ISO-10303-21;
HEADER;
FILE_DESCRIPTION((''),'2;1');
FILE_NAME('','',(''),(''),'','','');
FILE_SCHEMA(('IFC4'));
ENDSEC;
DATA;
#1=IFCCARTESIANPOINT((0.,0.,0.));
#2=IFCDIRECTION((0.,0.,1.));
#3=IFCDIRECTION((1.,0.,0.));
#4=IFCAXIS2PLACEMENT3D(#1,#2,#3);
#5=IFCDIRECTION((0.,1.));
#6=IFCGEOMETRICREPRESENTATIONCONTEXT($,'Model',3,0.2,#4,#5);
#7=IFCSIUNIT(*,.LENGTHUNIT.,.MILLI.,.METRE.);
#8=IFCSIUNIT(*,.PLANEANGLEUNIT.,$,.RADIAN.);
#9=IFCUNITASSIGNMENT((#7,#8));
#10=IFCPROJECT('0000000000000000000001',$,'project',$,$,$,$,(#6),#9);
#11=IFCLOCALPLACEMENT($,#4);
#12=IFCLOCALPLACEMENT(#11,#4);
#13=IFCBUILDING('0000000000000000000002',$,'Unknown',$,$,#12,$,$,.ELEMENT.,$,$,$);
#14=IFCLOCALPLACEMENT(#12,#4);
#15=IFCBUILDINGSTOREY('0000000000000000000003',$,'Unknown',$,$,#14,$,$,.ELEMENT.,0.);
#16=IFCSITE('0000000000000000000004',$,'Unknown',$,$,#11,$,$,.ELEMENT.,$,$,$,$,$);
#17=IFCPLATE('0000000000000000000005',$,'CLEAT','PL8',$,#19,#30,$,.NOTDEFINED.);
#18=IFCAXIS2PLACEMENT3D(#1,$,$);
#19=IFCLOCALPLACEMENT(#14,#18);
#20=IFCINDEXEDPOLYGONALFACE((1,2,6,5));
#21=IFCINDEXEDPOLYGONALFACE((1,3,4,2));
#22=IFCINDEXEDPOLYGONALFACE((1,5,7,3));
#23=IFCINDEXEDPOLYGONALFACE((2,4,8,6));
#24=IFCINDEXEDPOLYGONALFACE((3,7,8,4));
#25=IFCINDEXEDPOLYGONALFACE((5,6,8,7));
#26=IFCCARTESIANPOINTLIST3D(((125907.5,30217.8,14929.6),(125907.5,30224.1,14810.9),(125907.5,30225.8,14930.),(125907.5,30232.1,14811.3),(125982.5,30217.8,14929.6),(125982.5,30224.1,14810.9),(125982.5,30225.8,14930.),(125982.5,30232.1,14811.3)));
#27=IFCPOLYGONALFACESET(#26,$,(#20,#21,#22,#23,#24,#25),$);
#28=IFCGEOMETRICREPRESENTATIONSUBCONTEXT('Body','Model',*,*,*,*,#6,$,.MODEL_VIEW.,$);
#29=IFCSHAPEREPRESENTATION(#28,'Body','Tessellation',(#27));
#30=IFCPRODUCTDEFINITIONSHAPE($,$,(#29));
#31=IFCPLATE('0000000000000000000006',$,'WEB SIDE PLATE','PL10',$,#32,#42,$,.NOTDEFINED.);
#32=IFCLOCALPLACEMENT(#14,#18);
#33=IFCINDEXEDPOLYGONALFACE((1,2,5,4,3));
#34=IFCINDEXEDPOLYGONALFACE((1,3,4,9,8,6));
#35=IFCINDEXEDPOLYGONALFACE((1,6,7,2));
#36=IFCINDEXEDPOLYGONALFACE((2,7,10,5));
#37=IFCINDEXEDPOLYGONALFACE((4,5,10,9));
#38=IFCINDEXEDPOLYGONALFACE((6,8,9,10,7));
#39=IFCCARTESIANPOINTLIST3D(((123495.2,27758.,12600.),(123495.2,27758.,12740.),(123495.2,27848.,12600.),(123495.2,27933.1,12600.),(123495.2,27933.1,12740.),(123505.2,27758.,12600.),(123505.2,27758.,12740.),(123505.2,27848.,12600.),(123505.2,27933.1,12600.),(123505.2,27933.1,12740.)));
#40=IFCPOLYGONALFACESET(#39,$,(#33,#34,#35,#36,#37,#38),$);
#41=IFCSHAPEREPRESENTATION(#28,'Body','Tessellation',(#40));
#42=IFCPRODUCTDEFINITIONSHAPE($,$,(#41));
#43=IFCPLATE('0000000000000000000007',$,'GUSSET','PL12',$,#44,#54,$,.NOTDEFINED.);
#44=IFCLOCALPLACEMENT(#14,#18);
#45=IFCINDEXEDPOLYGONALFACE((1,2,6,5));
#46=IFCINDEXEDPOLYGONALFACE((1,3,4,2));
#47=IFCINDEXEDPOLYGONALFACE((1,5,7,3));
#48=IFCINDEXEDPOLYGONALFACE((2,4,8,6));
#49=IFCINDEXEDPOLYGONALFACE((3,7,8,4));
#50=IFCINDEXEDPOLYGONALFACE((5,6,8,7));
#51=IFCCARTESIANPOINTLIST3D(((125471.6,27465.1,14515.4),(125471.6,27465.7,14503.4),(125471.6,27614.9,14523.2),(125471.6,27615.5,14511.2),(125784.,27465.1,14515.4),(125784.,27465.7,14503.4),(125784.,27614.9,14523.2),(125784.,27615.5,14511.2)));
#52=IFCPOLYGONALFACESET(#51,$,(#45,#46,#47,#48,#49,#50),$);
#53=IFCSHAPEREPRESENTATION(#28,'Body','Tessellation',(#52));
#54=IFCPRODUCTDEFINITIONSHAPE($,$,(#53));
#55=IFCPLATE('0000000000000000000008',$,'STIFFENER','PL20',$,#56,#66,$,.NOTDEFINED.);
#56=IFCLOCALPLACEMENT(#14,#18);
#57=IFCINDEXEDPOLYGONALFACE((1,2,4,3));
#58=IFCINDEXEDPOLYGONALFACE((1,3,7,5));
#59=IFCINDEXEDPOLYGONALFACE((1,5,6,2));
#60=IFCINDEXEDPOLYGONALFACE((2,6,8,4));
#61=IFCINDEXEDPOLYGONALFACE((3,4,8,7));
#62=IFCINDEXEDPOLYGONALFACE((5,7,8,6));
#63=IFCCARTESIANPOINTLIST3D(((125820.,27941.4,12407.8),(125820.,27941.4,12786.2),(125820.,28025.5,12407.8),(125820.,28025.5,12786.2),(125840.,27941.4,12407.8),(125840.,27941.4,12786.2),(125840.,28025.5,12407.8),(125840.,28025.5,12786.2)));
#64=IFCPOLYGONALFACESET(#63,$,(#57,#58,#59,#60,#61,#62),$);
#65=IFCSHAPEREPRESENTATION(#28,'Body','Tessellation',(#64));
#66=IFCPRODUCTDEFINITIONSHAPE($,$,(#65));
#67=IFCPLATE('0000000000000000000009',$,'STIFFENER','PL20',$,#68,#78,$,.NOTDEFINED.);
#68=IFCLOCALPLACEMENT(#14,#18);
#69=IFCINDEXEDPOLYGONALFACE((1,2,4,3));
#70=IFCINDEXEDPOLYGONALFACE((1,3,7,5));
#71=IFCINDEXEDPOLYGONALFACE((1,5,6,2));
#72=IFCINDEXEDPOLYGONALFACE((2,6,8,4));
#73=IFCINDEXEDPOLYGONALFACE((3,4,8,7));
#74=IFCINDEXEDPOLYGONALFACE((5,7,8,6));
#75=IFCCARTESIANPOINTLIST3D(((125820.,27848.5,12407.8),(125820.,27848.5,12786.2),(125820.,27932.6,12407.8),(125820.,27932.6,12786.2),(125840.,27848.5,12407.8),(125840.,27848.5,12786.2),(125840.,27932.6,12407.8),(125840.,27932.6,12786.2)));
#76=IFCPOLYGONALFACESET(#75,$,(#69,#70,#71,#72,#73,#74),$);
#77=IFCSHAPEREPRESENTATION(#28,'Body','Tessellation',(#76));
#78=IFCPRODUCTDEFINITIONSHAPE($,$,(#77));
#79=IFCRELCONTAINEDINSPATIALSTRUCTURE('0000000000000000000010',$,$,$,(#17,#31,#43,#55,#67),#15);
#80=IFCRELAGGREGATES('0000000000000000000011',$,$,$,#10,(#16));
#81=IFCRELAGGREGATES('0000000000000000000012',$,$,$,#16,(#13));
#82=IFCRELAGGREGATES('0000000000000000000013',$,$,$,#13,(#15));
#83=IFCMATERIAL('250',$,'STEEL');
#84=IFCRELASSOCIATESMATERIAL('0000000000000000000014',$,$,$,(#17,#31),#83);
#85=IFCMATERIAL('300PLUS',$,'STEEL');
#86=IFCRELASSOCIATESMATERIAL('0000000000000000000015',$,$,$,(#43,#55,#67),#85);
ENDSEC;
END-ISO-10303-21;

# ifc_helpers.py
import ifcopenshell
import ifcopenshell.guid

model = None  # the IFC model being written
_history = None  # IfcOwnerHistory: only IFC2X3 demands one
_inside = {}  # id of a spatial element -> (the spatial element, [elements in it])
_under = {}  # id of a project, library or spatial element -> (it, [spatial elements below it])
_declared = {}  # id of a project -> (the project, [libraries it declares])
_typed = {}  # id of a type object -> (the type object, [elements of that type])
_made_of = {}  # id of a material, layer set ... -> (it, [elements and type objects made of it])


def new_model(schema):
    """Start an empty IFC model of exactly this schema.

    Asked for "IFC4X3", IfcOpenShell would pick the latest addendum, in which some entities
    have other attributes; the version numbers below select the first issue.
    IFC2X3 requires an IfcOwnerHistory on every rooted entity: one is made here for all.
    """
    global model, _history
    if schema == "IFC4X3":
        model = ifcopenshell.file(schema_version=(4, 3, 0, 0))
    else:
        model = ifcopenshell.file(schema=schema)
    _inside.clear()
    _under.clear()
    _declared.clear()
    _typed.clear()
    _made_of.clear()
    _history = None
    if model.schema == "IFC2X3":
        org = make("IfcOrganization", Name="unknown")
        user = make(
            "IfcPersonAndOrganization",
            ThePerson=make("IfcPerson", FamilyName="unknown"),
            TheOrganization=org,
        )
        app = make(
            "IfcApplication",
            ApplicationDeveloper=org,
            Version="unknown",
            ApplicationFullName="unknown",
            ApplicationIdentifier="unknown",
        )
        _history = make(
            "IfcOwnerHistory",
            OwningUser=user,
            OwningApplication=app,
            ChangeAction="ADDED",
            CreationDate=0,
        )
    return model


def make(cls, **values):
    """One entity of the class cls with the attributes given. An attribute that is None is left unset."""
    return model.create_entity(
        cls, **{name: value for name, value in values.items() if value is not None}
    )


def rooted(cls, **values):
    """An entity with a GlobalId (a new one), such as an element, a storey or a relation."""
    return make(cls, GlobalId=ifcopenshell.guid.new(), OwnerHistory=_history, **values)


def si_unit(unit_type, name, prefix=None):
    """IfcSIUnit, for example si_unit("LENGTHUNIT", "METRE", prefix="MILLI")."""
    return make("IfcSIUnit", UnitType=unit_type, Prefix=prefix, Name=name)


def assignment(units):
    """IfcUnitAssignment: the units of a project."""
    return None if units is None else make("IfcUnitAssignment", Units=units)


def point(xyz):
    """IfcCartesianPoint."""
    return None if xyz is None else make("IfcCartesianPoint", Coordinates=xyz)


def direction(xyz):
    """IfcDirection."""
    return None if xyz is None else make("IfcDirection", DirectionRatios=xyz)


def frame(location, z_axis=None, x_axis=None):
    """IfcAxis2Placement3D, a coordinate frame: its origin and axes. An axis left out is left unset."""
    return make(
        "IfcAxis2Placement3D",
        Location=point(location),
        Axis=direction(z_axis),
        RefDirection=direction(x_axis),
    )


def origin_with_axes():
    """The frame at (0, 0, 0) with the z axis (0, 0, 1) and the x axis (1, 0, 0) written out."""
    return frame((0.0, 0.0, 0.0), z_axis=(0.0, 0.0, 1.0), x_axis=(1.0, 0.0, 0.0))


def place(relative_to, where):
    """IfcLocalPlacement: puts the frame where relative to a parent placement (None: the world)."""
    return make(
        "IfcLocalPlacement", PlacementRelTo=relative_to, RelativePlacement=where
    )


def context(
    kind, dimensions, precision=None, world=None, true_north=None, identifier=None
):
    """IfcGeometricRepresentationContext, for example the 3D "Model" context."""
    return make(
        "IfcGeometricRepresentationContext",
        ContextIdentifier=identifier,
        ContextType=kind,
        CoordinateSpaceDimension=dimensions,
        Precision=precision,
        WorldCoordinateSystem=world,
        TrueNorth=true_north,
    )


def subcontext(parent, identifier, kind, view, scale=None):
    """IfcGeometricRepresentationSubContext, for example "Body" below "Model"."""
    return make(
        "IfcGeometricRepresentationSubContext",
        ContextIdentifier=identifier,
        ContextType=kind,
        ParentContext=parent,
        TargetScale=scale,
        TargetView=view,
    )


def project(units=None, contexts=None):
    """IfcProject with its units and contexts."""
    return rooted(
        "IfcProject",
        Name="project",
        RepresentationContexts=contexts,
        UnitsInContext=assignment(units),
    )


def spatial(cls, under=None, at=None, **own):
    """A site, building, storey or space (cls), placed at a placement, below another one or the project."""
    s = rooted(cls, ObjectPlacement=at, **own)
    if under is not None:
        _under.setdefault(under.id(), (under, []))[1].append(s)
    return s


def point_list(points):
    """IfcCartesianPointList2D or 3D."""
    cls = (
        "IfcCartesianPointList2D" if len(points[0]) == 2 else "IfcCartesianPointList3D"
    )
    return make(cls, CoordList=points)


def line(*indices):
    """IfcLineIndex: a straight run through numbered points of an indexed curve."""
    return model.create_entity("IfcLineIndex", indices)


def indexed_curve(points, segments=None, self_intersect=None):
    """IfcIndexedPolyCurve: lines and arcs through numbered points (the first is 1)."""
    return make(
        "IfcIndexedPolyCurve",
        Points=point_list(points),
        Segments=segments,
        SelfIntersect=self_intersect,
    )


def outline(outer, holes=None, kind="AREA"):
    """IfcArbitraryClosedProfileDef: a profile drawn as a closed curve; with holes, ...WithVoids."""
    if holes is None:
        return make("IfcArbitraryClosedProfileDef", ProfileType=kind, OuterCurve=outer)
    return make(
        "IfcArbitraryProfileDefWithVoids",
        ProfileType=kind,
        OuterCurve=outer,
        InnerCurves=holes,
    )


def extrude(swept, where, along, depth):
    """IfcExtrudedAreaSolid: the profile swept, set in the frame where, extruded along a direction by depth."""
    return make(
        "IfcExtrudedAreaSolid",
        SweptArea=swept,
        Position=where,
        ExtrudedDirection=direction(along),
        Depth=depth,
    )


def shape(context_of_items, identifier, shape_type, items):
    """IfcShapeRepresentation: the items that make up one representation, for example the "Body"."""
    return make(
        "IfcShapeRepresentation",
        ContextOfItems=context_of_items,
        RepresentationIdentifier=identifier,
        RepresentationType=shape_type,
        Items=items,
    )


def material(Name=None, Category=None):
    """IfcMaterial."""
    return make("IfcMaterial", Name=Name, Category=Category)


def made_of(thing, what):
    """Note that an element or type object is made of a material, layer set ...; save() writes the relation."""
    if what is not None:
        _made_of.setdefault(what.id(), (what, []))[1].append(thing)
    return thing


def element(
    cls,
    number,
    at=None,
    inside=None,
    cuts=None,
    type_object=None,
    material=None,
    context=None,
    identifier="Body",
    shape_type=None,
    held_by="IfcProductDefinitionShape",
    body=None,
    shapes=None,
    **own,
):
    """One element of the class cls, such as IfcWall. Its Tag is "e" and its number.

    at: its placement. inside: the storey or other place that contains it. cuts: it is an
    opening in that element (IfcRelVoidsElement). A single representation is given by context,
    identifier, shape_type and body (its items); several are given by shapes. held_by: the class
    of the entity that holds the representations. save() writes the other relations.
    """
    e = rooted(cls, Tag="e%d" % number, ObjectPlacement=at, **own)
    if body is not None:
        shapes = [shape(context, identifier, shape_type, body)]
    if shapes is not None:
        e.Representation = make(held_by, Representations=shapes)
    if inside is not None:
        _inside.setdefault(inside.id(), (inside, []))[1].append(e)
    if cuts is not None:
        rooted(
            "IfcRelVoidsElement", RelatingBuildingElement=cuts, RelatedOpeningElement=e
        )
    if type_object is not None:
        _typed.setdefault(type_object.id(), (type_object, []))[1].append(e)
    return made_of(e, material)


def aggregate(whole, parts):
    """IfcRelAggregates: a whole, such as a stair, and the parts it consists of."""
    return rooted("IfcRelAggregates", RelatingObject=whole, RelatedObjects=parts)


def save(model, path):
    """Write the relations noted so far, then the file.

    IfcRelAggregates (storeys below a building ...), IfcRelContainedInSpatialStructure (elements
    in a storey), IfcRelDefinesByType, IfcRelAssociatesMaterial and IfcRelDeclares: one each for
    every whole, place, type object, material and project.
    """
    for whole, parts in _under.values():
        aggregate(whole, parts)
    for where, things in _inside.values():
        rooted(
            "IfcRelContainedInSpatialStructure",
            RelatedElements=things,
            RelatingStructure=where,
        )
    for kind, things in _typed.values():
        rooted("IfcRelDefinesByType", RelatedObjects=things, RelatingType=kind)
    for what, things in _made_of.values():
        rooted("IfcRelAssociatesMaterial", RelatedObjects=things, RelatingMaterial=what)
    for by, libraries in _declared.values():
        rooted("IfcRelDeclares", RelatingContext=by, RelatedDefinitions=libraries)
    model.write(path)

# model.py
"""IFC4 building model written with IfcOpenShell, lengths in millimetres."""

from ifc_helpers import new_model, si_unit, direction, frame, origin_with_axes, place, context, subcontext, project, spatial, line, indexed_curve, outline, extrude, material, element, save


model = new_model("IFC4")

# Units and contexts
model_context = context("Model", 3, precision=0.2, world=origin_with_axes(), true_north=direction((0.0, 1.0)))
body_context = subcontext(model_context, "Body", "Model", "MODEL_VIEW")
ifc_project = project(units=[si_unit("LENGTHUNIT", "METRE", prefix="MILLI"), si_unit("PLANEANGLEUNIT", "RADIAN")], contexts=[model_context])

# Site, building, storey
site_placement = place(None, origin_with_axes())
site = spatial("IfcSite", under=ifc_project, at=site_placement, Name="Unknown", CompositionType="ELEMENT")
building_placement = place(site_placement, origin_with_axes())
building = spatial("IfcBuilding", under=site, at=building_placement, Name="Unknown", CompositionType="ELEMENT")
storey_placement = place(building_placement, origin_with_axes())
storey = spatial("IfcBuildingStorey", under=building, at=storey_placement, Name="Unknown", CompositionType="ELEMENT", Elevation=0.0)

# Shared definitions
ifc_material_1 = material(Name="300PLUS", Category="STEEL")

# Plates
ifc_material_2 = material(Name="250", Category="STEEL")
plate_1_placement = place(storey_placement, frame((125907.5, 30221.8, 14929.8), z_axis=(0.0, 0.998594, 0.053), x_axis=(1.0, 0.0, 0.0)))
element("IfcPlate", 1, at=plate_1_placement, inside=storey, material=ifc_material_2, Name="CLEAT", Description="PL8", PredefinedType="NOTDEFINED", context=body_context, shape_type="SolidModel", body=[
    extrude(outline(indexed_curve([(0.0, 0.0), (75.0, 0.0), (75.0, 118.9), (0.0, 118.9)], segments=[line(1, 2, 3, 4, 1)])), frame((0.0, 0.0, 4.0), z_axis=(0.0, 0.0, 1.0), x_axis=(1.0, 0.0, 0.0)), (0.0, 0.0, -1.0), 8.0),
])
plate_2_placement = place(storey_placement, frame((123500.2, 27848.0, 12600.0), z_axis=(1.0, 0.0, 0.0), x_axis=(0.0, 1.0, 0.0)))
element("IfcPlate", 2, at=plate_2_placement, inside=storey, material=ifc_material_2, Name="WEB SIDE PLATE", Description="PL10", PredefinedType="NOTDEFINED", context=body_context, shape_type="SolidModel", body=[
    extrude(outline(indexed_curve([(0.0, 0.0), (85.1, 0.0), (85.1, 140.0), (-90.0, 140.0), (-90.0, 0.0)], segments=[line(1, 2, 3, 4, 5, 1)])), frame((0.0, 0.0, 5.0), z_axis=(0.0, 0.0, 1.0), x_axis=(1.0, 0.0, 0.0)), (0.0, 0.0, -1.0), 10.0),
])
plate_3_placement = place(storey_placement, frame((125784.0, 27615.2, 14517.2), z_axis=(0.0, -0.051999, 0.998647), x_axis=(-1.0, 0.0, 0.0)))
element("IfcPlate", 3, at=plate_3_placement, inside=storey, material=ifc_material_1, Name="GUSSET", Description="PL12", PredefinedType="NOTDEFINED", context=body_context, shape_type="SolidModel", body=[
    extrude(outline(indexed_curve([(0.0, 0.0), (312.4, 0.0), (312.4, 150.0), (0.0, 150.0)], segments=[line(1, 2, 3, 4, 1)])), frame((0.0, 0.0, 6.0), z_axis=(0.0, 0.0, 1.0), x_axis=(1.0, 0.0, 0.0)), (0.0, 0.0, -1.0), 12.0),
])
for number, where, z_axis, x_axis, name in (
    (4, (125830.0, 28025.5, 12407.8), (1.0, 0.0, 0.0), (0.0, 0.0, 1.0), "STIFFENER"),
    (5, (125830.0, 27932.6, 12407.8), (1.0, 0.0, 0.0), (0.0, 0.0, 1.0), "STIFFENER"),
):
    element("IfcPlate", number, at=place(storey_placement, frame(where, z_axis=z_axis, x_axis=x_axis)), inside=storey, material=ifc_material_1, Name=name, Description="PL20", PredefinedType="NOTDEFINED", context=body_context, shape_type="SolidModel", body=[
        extrude(outline(indexed_curve([(0.0, 0.0), (378.4, 0.0), (378.4, 84.1), (0.0, 84.1)], segments=[line(1, 2, 3, 4, 1)])), frame((0.0, 0.0, 10.0), z_axis=(0.0, 0.0, 1.0), x_axis=(1.0, 0.0, 0.0)), (0.0, 0.0, -1.0), 20.0),
    ])

save(model, "model.ifc")
